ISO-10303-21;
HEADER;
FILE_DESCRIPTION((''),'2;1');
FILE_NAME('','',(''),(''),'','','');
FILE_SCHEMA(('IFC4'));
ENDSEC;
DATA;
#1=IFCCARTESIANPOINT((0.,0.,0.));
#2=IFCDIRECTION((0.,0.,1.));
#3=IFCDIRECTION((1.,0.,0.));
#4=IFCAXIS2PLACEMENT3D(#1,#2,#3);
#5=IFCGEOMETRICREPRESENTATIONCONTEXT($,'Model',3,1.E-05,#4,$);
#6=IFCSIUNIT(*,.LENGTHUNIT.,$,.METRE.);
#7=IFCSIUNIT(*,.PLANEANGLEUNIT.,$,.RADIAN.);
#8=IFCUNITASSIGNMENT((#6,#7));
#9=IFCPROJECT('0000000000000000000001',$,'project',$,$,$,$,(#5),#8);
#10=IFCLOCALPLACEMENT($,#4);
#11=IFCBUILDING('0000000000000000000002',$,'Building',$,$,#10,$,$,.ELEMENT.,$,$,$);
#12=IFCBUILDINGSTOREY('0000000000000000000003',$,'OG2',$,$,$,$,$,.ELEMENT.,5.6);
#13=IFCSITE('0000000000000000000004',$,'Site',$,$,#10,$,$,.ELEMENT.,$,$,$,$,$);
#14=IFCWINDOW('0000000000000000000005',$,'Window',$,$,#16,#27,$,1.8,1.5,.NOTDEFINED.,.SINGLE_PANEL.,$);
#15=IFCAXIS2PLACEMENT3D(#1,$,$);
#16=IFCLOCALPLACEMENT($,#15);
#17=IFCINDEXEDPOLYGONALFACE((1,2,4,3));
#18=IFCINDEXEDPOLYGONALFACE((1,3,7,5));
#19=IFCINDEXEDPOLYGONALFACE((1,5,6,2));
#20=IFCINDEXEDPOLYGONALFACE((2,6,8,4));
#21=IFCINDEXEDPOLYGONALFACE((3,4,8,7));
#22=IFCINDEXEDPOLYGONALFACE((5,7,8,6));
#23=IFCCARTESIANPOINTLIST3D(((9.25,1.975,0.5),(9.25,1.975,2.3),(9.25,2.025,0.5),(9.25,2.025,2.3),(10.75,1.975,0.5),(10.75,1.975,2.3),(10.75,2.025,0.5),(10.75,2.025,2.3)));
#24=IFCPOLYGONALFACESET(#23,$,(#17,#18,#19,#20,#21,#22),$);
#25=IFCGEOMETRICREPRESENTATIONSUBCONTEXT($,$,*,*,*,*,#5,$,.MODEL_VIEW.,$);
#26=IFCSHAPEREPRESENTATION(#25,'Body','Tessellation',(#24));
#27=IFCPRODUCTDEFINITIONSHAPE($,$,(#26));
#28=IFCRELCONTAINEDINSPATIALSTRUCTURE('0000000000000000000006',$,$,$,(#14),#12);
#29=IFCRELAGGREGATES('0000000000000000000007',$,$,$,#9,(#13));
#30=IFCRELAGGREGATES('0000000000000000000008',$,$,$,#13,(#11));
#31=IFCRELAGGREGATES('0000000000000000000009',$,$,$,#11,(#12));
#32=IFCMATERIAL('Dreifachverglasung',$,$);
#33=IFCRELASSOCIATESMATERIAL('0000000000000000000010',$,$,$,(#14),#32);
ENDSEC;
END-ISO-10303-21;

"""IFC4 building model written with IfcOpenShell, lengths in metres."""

from ifc_helpers import new_model, si_unit, frame, origin, origin_with_axes, origin_2d, place, context, subcontext, project, spatial, rectangle, extrude, material, element, save


model = new_model("IFC4")

# Units and contexts
model_context = context("Model", 3, precision=1e-05, world=origin_with_axes())
sub_context = subcontext(model_context, None, None, "MODEL_VIEW")
ifc_project = project(units=[si_unit("LENGTHUNIT", "METRE"), si_unit("PLANEANGLEUNIT", "RADIAN")], contexts=[model_context])

# Site, building, storey
placement_1 = place(None, origin_with_axes())
site = spatial("IfcSite", under=ifc_project, at=placement_1, Name="Site", CompositionType="ELEMENT")
building = spatial("IfcBuilding", under=site, at=placement_1, Name="Building", CompositionType="ELEMENT")
storey = spatial("IfcBuildingStorey", under=building, Name="OG2", CompositionType="ELEMENT", Elevation=5.6)

# Window
ifc_material = material(Name="Dreifachverglasung")
placement_2 = place(None, origin_with_axes())
window_placement = place(placement_2, frame((10.0, 2.0, 0.5)))
element("IfcWindow", 1, at=window_placement, inside=storey, material=ifc_material, Name="Window", OverallHeight=1.8, OverallWidth=1.5, PartitioningType="SINGLE_PANEL", PredefinedType="NOTDEFINED", context=sub_context, shape_type="SweptSolid", body=[
    extrude(rectangle(XDim=1.5, YDim=0.05, at=origin_2d()), origin(), (0.0, 0.0, 1.0), 1.8),
])

save(model, "model.ifc")
